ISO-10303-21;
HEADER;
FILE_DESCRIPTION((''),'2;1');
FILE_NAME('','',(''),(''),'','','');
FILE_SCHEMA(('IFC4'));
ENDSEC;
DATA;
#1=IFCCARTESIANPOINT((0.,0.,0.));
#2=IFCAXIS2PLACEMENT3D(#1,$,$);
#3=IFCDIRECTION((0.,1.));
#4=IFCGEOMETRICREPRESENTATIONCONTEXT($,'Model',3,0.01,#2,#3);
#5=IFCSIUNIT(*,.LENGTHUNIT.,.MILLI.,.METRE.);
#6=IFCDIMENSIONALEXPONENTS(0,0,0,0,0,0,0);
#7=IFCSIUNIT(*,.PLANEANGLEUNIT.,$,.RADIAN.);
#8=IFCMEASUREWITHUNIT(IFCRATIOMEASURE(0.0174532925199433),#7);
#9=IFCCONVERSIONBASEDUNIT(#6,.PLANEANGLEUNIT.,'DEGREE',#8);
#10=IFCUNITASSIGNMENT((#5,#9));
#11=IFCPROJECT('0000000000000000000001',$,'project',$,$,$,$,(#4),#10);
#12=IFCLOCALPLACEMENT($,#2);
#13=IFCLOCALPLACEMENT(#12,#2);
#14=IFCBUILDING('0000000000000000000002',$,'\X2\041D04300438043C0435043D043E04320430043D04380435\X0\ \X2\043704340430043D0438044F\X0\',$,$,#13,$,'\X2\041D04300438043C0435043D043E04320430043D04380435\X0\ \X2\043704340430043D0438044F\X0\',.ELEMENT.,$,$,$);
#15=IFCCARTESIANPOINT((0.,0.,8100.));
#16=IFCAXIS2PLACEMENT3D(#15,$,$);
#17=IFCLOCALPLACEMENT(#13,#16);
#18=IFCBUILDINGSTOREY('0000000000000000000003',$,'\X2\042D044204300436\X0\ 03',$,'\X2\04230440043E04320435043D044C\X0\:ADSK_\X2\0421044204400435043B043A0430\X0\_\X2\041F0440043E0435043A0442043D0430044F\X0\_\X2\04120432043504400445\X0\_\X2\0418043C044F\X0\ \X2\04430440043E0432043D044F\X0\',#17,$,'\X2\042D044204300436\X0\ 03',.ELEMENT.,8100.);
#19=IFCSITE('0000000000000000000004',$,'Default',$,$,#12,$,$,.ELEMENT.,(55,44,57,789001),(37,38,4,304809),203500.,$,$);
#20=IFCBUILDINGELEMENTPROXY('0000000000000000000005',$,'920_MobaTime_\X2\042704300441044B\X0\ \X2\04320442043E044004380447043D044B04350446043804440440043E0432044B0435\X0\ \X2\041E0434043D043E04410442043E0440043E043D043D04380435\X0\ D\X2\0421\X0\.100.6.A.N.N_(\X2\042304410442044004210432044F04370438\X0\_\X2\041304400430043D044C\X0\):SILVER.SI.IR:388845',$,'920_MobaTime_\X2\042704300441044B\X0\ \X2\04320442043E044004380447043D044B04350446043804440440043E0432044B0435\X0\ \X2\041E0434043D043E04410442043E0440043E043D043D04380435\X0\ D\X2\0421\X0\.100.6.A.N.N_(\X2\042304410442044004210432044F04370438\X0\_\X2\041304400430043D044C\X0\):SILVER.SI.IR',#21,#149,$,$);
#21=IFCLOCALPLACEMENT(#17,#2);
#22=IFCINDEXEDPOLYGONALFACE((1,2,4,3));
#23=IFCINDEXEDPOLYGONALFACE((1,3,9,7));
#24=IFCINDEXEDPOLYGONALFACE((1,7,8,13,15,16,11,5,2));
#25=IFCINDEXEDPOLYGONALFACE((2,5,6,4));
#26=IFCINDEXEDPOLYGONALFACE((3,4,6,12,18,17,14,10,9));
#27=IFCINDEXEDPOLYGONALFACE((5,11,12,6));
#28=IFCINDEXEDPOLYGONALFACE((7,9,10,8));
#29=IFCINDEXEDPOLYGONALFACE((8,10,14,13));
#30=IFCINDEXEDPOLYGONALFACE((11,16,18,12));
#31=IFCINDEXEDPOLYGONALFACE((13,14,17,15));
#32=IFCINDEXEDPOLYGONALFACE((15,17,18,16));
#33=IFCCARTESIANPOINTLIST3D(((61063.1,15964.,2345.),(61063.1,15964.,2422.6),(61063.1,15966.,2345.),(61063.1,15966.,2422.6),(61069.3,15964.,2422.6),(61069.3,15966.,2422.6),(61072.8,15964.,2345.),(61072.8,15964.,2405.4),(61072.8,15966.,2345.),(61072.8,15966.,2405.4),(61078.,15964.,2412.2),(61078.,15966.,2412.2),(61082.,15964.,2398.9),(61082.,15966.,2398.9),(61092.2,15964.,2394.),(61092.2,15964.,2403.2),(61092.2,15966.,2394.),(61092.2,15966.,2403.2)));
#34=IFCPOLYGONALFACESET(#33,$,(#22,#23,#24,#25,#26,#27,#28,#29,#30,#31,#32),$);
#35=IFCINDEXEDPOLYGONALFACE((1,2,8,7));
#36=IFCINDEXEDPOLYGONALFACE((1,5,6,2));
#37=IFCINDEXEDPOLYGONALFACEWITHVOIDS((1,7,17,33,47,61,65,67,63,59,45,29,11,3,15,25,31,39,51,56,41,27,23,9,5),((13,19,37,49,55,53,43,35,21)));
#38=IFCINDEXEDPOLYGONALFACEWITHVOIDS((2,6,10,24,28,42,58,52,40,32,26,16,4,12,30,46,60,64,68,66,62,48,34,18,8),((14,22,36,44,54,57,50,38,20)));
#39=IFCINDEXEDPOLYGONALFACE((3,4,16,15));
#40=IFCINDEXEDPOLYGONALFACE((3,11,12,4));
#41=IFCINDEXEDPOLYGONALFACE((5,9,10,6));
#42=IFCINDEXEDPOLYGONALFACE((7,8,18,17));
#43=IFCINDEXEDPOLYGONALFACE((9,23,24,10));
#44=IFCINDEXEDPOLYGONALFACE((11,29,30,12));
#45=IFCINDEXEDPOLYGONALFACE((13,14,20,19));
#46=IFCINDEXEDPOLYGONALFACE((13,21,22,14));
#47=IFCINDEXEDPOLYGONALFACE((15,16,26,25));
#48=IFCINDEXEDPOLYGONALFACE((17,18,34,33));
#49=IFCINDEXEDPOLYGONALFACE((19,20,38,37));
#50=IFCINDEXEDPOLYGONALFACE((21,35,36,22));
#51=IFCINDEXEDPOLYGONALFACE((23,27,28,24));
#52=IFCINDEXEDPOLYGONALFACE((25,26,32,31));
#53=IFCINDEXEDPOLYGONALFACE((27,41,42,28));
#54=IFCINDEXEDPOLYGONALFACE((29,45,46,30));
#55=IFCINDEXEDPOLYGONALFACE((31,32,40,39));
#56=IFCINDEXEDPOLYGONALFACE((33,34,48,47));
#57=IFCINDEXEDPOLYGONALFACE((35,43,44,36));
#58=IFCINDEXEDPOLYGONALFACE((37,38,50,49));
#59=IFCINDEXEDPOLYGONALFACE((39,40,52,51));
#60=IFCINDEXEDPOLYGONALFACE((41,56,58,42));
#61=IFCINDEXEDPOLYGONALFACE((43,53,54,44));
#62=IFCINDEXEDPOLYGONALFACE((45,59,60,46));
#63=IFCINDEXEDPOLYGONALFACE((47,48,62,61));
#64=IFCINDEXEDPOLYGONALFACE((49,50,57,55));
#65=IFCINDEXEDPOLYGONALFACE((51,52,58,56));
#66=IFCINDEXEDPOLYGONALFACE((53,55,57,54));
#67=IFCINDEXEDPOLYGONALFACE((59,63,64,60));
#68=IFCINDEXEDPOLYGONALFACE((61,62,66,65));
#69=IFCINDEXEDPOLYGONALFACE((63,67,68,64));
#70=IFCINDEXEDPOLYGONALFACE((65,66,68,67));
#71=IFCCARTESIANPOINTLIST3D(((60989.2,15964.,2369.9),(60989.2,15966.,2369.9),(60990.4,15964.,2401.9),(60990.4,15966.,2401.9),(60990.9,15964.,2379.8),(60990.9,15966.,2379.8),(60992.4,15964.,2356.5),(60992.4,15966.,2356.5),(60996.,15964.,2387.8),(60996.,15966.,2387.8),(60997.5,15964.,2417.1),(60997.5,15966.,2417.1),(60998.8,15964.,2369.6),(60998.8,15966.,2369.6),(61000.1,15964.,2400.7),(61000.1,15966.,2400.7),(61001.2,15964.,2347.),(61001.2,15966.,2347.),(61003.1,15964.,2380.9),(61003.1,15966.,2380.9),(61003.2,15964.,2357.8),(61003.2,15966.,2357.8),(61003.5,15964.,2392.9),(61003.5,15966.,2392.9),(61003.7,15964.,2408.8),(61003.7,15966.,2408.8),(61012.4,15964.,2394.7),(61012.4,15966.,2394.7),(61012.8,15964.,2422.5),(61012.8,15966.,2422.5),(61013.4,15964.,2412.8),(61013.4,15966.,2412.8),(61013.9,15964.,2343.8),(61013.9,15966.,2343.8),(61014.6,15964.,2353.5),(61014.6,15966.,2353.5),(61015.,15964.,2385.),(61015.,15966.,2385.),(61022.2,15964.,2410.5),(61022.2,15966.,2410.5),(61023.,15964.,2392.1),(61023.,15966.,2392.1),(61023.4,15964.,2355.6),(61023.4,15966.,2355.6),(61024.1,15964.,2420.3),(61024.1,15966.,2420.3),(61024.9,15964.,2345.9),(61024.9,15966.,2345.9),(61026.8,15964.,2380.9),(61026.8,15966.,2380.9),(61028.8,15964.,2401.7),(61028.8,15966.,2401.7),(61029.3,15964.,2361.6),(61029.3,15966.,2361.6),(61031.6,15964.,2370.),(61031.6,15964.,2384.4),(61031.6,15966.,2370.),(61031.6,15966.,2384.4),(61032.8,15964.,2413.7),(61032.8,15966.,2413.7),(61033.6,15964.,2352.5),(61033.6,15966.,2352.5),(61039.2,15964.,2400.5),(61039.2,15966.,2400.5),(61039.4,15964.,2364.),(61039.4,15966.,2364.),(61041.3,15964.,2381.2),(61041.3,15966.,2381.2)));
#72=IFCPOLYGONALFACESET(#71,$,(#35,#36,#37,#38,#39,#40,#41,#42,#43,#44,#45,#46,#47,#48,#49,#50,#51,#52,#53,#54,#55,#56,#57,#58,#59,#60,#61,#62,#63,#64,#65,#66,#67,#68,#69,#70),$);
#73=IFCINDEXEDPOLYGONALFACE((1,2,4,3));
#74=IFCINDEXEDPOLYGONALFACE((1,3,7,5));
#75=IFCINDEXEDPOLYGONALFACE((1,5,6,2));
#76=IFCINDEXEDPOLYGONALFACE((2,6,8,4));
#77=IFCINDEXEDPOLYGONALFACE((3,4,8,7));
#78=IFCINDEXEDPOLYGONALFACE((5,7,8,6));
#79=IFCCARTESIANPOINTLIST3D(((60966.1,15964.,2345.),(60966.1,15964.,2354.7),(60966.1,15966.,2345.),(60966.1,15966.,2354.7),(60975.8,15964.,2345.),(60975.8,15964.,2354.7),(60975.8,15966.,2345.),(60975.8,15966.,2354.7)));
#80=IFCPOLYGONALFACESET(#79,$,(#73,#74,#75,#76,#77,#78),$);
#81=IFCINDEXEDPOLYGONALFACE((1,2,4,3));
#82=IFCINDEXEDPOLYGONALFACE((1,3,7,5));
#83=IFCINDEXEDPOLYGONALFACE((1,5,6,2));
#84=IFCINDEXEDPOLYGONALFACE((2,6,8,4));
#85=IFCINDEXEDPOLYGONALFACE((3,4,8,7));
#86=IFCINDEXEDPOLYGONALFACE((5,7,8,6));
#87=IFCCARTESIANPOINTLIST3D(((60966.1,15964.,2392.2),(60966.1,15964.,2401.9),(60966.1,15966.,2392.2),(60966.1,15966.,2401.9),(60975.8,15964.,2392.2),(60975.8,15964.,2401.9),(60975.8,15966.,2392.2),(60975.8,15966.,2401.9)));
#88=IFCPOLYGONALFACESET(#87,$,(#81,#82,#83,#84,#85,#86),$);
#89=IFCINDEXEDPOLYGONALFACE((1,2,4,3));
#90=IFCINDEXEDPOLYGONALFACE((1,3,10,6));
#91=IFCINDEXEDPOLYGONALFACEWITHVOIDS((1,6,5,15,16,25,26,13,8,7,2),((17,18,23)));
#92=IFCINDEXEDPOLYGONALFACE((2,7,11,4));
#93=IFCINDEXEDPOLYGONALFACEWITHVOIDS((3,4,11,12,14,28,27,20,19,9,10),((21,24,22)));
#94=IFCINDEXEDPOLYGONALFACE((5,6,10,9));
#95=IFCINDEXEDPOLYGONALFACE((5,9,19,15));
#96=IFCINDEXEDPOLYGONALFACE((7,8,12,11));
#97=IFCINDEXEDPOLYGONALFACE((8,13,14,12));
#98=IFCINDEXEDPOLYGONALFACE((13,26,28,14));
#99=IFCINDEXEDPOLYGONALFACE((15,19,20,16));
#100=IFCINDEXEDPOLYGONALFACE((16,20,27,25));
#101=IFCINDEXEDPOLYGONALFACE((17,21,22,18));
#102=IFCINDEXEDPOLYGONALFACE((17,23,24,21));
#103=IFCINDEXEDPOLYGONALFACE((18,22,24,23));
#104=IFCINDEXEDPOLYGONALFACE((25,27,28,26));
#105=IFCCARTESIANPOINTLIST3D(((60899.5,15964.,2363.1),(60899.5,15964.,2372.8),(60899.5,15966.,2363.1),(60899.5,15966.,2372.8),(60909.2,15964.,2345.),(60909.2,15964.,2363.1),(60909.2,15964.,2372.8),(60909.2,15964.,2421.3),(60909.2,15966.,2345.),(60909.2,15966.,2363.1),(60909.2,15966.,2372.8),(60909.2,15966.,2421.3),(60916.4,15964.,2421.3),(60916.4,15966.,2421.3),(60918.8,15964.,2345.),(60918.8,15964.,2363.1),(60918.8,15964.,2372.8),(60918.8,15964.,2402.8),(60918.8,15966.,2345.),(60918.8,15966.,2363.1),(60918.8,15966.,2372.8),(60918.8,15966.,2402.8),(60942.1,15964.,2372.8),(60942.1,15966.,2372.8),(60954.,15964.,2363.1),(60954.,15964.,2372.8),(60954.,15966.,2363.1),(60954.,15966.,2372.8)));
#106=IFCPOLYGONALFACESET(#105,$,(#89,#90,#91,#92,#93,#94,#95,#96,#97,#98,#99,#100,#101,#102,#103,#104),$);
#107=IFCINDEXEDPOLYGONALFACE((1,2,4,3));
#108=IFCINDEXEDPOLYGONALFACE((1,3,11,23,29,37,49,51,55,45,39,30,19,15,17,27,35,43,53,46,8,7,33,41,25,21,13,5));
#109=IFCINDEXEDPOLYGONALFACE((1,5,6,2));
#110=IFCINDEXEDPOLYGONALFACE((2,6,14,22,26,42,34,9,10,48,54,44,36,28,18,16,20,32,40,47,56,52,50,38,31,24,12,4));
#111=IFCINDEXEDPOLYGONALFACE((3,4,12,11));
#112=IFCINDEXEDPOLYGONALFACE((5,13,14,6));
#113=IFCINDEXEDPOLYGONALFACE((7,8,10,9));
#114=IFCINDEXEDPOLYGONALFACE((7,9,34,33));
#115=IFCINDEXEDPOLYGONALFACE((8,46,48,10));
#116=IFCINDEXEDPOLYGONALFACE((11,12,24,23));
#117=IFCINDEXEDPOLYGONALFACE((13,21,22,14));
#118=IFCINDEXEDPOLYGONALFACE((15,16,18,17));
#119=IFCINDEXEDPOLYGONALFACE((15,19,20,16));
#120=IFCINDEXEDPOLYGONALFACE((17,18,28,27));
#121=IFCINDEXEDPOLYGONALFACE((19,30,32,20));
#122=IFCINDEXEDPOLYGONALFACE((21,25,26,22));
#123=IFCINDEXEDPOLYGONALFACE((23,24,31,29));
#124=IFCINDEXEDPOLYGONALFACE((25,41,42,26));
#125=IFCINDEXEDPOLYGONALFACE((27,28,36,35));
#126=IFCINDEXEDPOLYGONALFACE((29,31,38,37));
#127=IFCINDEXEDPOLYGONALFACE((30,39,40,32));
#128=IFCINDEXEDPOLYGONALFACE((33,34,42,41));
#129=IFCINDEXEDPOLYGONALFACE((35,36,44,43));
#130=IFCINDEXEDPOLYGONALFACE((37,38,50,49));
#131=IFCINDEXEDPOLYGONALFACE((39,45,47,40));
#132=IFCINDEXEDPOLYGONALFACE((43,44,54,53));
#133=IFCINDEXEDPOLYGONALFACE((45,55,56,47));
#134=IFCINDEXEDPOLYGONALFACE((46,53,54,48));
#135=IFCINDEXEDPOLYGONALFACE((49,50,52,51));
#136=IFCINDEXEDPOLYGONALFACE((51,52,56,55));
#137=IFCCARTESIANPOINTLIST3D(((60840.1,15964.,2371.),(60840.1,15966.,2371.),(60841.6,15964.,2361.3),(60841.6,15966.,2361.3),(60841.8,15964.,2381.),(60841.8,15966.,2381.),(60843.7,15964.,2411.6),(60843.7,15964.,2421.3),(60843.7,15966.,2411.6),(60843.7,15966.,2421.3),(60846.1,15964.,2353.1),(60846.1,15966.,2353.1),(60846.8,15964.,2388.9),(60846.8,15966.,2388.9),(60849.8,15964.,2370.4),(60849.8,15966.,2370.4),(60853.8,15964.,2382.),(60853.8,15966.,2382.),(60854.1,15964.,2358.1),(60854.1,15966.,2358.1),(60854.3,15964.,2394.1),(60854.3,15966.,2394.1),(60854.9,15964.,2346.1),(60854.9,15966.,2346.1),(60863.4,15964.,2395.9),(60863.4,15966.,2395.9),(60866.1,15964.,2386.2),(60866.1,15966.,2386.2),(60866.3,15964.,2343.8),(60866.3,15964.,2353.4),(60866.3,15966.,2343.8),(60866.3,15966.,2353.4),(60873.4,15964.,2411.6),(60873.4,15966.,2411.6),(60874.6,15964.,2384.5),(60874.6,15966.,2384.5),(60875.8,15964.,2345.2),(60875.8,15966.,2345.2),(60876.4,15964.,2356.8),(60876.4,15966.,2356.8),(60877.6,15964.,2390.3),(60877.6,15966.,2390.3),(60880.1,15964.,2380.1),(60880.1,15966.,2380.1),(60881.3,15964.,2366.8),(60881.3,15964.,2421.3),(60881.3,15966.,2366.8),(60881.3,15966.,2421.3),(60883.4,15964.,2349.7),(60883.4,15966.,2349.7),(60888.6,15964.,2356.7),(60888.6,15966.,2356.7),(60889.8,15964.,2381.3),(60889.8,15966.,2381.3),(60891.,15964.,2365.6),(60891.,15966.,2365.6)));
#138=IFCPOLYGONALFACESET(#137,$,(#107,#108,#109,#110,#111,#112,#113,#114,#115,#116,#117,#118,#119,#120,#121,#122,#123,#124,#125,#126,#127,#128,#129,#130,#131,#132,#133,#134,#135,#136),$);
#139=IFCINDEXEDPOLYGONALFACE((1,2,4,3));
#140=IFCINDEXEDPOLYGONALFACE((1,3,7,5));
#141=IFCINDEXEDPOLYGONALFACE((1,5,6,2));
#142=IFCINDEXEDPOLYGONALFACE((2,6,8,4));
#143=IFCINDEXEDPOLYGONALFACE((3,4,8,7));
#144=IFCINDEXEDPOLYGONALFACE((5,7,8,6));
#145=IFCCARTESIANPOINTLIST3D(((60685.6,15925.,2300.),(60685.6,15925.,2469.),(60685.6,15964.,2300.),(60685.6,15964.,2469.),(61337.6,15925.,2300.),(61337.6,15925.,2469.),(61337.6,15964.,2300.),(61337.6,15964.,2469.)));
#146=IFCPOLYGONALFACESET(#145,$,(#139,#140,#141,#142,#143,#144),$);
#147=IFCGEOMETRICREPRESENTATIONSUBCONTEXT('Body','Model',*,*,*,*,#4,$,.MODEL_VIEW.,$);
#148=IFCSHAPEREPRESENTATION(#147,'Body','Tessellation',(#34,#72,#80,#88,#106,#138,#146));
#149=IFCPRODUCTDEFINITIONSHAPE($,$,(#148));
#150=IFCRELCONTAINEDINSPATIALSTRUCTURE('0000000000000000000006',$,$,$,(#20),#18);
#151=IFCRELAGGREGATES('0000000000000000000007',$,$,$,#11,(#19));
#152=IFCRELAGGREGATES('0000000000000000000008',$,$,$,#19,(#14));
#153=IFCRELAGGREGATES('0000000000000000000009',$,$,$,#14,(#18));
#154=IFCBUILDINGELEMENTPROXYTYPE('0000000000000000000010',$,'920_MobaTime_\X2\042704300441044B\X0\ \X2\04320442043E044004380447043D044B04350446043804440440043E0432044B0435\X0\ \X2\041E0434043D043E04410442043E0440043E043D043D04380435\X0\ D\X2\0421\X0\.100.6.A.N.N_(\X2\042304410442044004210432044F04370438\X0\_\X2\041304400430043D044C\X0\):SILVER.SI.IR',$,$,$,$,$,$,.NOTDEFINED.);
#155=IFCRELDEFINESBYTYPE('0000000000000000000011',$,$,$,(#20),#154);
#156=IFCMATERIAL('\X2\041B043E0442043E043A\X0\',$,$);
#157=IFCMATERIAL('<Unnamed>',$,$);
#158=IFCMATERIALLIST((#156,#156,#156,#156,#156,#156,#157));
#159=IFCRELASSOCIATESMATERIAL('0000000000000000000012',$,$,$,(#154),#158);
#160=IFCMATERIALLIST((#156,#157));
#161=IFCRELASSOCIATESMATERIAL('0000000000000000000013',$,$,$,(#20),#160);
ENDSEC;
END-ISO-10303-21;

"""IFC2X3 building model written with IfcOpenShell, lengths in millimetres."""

from ifc_helpers import new_model, entity, si_unit, converted_unit, direction, frame, origin, origin_2d_with_axis, place, context, subcontext, project, spatial, polyline, rectangle, outline, extrude, source, transform, mapped, material, material_list, type_object, type_shapes, element, save


model = new_model("IFC2X3")

# Units and contexts
model_context = context("Model", 3, precision=0.01, world=origin(), true_north=direction((0.0, 1.0)))
body_context = subcontext(model_context, "Body", "Model", "MODEL_VIEW")
ifc_project = project(units=[si_unit("LENGTHUNIT", "METRE", prefix="MILLI"), converted_unit("PLANEANGLEUNIT", "DEGREE", entity("IfcRatioMeasure", 0.0174532925199433), si_unit("PLANEANGLEUNIT", "RADIAN"), dimensions=[0, 0, 0, 0, 0, 0, 0])], contexts=[model_context])

# Site, building, storey
site_placement = place(None, origin())
site = spatial("IfcSite", under=ifc_project, at=site_placement, Name="Default", CompositionType="ELEMENT", RefLatitude=(55, 44, 57, 789001), RefLongitude=(37, 38, 4, 304809), RefElevation=203500.0)
building_placement = place(site_placement, origin())
building = spatial("IfcBuilding", under=site, at=building_placement, Name="Наименование здания", LongName="Наименование здания", CompositionType="ELEMENT")
storey_placement = place(building_placement, frame((0.0, 0.0, 8100.0)))
storey = spatial("IfcBuildingStorey", under=building, at=storey_placement, Name="Этаж 03", ObjectType="Уровень:ADSK_Стрелка_Проектная_Вверх_Имя уровня", LongName="Этаж 03", CompositionType="ELEMENT", Elevation=8100.0)

# Building element proxy
ifc_material_1 = material(Name="Лоток")
ifc_material_2 = material(Name="<Unnamed>")
ifc_material_list_1 = material_list([ifc_material_1, ifc_material_1, ifc_material_1, ifc_material_1, ifc_material_1, ifc_material_1, ifc_material_2])
building_element_proxy_type = type_object("IfcBuildingElementProxyType", Name="920_MobaTime_Часы вторичныецифровые Односторонние DС.100.6.A.N.N_(УстрСвязи_Грань):SILVER.SI.IR", PredefinedType="NOTDEFINED", material=ifc_material_list_1)
shared_shape = source(origin(), body_context, "Body", "SweptSolid", [
    extrude(outline(polyline([(-49.3, -13.1), (28.2, -13.1), (28.2, -6.8), (17.9, 1.8), (8.8, 16.0), (-0.3, 16.0), (4.6, 5.8), (11.1, -3.4), (-49.3, -3.4), (-49.3, -13.1)])), frame((-64.6, 9.8, 39.0), z_axis=(0.0, 0.0, 1.0), x_axis=(0.0, 1.0, 0.0)), (0.0, 0.0, 1.0), 2.0),
    extrude(outline(polyline([(2.2, -27.6), (19.0, -27.6), (30.5, -16.1), (33.3, -4.9), (31.0, 5.8), (21.8, 17.2), (5.2, 27.3), (-11.1, 33.0), (-24.0, 32.7), (-33.6, 27.6), (-40.3, 18.6), (-42.8, 5.7), (-38.0, -6.3), (-27.2, -14.9), (-17.5, -17.7), (-8.2, -16.4), (-0.3, -11.9), (5.1, -4.5), (7.3, 6.2), (4.0, 17.2), (18.4, 7.3), (23.6, -2.4), (22.0, -11.4), (14.2, -18.4), (5.3, -18.3), (2.2, -27.6)]), holes=[polyline([(-9.0, 23.3), (-1.3, 14.3), (-2.5, 2.0), (-11.4, -7.0), (-23.4, -6.0), (-32.2, 2.9), (-31.2, 15.1), (-25.6, 22.1), (-17.5, 24.9), (-9.0, 23.3)])]), frame((-2.7, 3.6, 39.0), z_axis=(0.0, 0.0, 1.0), x_axis=(-0.427649, 0.903945, 0.0)), (0.0, 0.0, 1.0), 2.0),
    extrude(rectangle(XDim=9.7, YDim=9.7, at=origin_2d_with_axis()), frame((40.6, -34.7, 39.0)), (0.0, 0.0, 1.0), 2.0),
    extrude(rectangle(XDim=9.7, YDim=9.7, at=origin_2d_with_axis()), frame((40.6, 12.6, 39.0)), (0.0, 0.0, 1.0), 2.0),
    extrude(outline(polyline([(-0.9, -28.1), (8.8, -28.1), (8.8, -9.9), (18.5, -9.9), (18.5, -0.2), (8.8, -0.2), (8.8, 48.3), (1.5, 48.3), (-36.0, -0.2), (-36.0, -9.9), (-0.9, -9.9), (-0.9, -28.1)]), holes=[polyline([(-0.9, -0.2), (-24.1, -0.2), (-0.9, 29.7), (-0.9, -0.2)])]), frame((93.6, -11.4, 39.0)), (0.0, 0.0, 1.0), 2.0),
    extrude(outline(polyline([(3.3, -28.3), (12.5, -28.3), (20.5, -25.0), (26.8, -18.9), (30.7, -10.0), (31.4, 1.6), (26.9, 11.8), (20.1, 18.4), (11.1, 22.3), (1.0, 23.3), (-7.9, 20.4), (-14.9, 14.5), (-18.9, 6.2), (-17.1, -9.0), (-36.7, 0.5), (-29.1, 29.2), (-38.5, 31.7), (-48.1, -4.6), (-11.6, -23.1), (-8.0, -14.0), (-10.8, -7.6), (-10.2, 1.1), (-3.0, 11.8), (9.2, 12.8), (20.0, 5.5), (21.4, -7.5), (15.5, -16.4), (4.6, -18.6), (3.3, -28.3)])), frame((147.1, -8.5, 39.0), z_axis=(0.0, 0.0, 1.0), x_axis=(0.256974, -0.966418, 0.0)), (0.0, 0.0, 1.0), 2.0),
    extrude(rectangle(XDim=652.0, YDim=169.0, at=origin_2d_with_axis()), frame((0.0, 0.0, 0.0), z_axis=(0.0, 0.0, 1.0), x_axis=(-1.0, 0.0, 0.0)), (0.0, 0.0, 1.0), 39.0),
])
type_shapes(building_element_proxy_type, [shared_shape])
ifc_material_list_2 = material_list([ifc_material_1, ifc_material_2])
for number, where, z_axis, x_axis, name in (
    (1, (61011.6, 15925.0, 2384.5), (0.0, 1.0, 0.0), (-1.0, 0.0, 0.0), "920_MobaTime_Часы вторичныецифровые Односторонние DС.100.6.A.N.N_(УстрСвязи_Грань):SILVER.SI.IR:388845"),
):
    element("IfcBuildingElementProxy", number, at=place(storey_placement, frame(where, z_axis=z_axis, x_axis=x_axis)), inside=storey, type_object=building_element_proxy_type, material=ifc_material_list_2, Name=name, ObjectType="920_MobaTime_Часы вторичныецифровые Односторонние DС.100.6.A.N.N_(УстрСвязи_Грань):SILVER.SI.IR", context=body_context, shape_type="MappedRepresentation", body=[
        mapped(shared_shape, transform((0.0, 0.0, 0.0), scale=1.0)),
    ])

save(model, "model.ifc")
